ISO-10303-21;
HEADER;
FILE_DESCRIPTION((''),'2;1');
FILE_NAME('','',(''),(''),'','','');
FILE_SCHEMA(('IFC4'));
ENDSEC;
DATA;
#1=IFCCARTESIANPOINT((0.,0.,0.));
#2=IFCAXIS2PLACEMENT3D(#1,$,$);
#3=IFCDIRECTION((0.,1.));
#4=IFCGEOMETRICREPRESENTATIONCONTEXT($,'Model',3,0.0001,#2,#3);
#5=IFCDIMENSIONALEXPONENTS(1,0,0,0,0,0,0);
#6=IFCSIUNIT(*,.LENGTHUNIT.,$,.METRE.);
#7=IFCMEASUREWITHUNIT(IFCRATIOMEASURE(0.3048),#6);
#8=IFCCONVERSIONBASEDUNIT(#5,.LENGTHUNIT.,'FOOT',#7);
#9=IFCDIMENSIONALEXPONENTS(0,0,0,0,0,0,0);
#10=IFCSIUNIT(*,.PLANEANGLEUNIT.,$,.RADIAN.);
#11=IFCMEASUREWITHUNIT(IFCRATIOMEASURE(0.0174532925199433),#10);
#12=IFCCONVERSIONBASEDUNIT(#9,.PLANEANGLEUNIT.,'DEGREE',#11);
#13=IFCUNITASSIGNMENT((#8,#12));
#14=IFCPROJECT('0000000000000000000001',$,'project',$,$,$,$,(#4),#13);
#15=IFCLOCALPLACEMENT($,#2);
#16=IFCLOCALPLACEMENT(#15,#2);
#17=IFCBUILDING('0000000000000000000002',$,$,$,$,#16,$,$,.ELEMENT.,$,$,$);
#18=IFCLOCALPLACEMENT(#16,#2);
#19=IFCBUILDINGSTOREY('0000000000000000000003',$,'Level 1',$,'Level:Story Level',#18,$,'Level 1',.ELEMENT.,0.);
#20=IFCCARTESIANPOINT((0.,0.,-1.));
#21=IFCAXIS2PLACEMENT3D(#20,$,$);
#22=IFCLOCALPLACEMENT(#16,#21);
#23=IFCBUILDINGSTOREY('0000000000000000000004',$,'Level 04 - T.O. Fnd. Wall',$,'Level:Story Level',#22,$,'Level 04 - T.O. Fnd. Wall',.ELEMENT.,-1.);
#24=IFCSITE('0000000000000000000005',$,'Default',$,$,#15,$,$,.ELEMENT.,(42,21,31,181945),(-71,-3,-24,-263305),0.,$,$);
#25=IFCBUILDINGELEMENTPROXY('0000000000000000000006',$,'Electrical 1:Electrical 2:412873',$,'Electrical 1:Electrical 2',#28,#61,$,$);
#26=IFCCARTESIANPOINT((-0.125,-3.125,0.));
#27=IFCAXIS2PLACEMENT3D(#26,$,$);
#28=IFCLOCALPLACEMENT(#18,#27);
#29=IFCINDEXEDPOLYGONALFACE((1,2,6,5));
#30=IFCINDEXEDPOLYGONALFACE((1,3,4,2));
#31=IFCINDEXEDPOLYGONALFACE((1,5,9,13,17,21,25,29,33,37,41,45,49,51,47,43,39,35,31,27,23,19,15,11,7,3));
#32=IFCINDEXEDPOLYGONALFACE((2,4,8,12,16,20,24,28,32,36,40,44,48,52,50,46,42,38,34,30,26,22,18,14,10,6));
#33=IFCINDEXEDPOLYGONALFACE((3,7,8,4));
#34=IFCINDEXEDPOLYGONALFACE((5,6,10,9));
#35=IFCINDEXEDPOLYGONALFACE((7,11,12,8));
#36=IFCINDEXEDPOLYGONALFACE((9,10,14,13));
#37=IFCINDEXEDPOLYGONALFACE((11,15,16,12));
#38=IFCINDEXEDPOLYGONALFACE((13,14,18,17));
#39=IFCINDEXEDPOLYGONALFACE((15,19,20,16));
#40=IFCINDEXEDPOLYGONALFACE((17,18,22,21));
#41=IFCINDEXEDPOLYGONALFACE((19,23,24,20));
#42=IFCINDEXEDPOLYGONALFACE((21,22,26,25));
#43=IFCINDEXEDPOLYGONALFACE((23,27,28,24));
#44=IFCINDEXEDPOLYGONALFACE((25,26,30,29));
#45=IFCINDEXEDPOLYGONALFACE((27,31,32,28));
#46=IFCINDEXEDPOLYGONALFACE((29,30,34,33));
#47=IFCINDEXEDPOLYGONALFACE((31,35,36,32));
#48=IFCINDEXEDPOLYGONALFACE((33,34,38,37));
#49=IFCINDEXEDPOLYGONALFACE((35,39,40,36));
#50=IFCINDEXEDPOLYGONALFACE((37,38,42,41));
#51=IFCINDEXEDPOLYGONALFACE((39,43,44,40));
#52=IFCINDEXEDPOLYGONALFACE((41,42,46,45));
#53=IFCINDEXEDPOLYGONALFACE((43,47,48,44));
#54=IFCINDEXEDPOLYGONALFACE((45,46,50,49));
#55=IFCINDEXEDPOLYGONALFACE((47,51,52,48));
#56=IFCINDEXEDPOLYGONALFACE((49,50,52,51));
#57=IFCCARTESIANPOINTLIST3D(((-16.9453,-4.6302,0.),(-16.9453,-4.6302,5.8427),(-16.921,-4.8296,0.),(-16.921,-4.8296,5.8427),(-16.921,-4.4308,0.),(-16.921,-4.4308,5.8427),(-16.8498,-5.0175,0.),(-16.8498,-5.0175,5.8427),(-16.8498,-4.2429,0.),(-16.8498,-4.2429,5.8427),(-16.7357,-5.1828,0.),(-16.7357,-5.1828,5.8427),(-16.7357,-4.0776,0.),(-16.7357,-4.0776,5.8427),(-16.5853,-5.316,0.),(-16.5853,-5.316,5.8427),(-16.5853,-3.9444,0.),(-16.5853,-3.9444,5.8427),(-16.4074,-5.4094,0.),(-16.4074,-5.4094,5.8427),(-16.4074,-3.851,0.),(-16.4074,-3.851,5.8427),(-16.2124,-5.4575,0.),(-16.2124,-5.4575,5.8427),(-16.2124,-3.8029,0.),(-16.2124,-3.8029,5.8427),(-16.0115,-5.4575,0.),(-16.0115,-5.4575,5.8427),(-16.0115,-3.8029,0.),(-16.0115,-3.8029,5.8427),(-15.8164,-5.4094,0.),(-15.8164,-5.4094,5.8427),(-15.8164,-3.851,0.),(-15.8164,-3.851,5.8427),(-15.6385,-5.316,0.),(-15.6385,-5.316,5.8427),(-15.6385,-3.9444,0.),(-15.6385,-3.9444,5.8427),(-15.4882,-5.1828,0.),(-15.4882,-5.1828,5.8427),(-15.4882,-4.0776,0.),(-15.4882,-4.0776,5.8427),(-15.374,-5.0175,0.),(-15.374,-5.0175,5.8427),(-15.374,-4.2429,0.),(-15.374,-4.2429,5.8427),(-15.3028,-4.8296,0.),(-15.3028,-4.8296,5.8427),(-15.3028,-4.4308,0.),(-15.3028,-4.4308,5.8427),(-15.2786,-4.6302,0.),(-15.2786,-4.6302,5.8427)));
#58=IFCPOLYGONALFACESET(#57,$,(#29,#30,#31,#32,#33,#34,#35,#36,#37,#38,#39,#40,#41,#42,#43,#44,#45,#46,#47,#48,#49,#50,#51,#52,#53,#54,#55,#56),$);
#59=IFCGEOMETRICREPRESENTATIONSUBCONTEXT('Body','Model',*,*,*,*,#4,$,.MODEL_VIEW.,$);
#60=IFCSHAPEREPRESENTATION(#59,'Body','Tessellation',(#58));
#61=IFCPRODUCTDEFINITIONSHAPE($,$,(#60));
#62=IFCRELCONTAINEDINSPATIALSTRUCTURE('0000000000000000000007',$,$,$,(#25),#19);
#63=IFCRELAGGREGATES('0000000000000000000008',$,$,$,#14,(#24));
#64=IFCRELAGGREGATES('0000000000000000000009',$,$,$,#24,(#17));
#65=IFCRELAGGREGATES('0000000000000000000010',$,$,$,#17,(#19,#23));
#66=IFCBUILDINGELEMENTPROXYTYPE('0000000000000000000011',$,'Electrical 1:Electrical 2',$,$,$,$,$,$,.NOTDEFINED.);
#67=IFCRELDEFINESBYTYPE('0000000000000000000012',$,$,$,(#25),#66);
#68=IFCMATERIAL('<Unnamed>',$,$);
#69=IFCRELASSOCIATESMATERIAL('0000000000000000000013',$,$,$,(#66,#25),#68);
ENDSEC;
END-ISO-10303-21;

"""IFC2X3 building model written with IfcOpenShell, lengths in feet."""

from ifc_helpers import new_model, entity, si_unit, converted_unit, direction, frame, frame_2d, origin, place, context, subcontext, project, spatial, circle, extrude, source, transform, mapped, material, type_object, type_shapes, element, save


model = new_model("IFC2X3")

# Units and contexts
model_context = context("Model", 3, precision=0.0001, world=origin(), true_north=direction((0.0, 1.0)))
body_context = subcontext(model_context, "Body", "Model", "MODEL_VIEW")
ifc_project = project(units=[converted_unit("LENGTHUNIT", "FOOT", entity("IfcRatioMeasure", 0.3048), si_unit("LENGTHUNIT", "METRE"), dimensions=[1, 0, 0, 0, 0, 0, 0]), converted_unit("PLANEANGLEUNIT", "DEGREE", entity("IfcRatioMeasure", 0.0174532925199433), si_unit("PLANEANGLEUNIT", "RADIAN"), dimensions=[0, 0, 0, 0, 0, 0, 0])], contexts=[model_context])

# Site, building, storey
site_placement = place(None, origin())
site = spatial("IfcSite", under=ifc_project, at=site_placement, Name="Default", CompositionType="ELEMENT", RefLatitude=(42, 21, 31, 181945), RefLongitude=(-71, -3, -24, -263305), RefElevation=0.0)
building_placement = place(site_placement, origin())
building = spatial("IfcBuilding", under=site, at=building_placement, CompositionType="ELEMENT")
storey_1_placement = place(building_placement, origin())
storey_1 = spatial("IfcBuildingStorey", under=building, at=storey_1_placement, Name="Level 1", ObjectType="Level:Story Level", LongName="Level 1", CompositionType="ELEMENT", Elevation=0.0)

# Shared definitions
storey_2_placement = place(building_placement, frame((0.0, 0.0, -1.0)))
storey_2 = spatial("IfcBuildingStorey", under=building, at=storey_2_placement, Name="Level 04 - T.O. Fnd. Wall", ObjectType="Level:Story Level", LongName="Level 04 - T.O. Fnd. Wall", CompositionType="ELEMENT", Elevation=-1.0)

# Shared definitions
ifc_material_1 = material(Name="<Unnamed>")

# Building element proxy
building_element_proxy_type = type_object("IfcBuildingElementProxyType", Name="Electrical 1:Electrical 2", PredefinedType="NOTDEFINED", material=ifc_material_1)
shared_shape_1 = source(origin(), body_context, "Body", "SweptSolid", [
    extrude(circle(Radius=0.8333, at=frame_2d((0.0, 0.0), x_axis=(1.0, 0.0))), frame((-16.1119, -4.6302, 0.0)), (0.0, 0.0, 1.0), 5.8427),
])
type_shapes(building_element_proxy_type, [shared_shape_1])
proxy_placement = place(storey_1_placement, frame((-0.125, -3.125, 0.0)))
element("IfcBuildingElementProxy", 1, at=proxy_placement, inside=storey_1, type_object=building_element_proxy_type, material=ifc_material_1, Name="Electrical 1:Electrical 2:412873", ObjectType="Electrical 1:Electrical 2", context=body_context, shape_type="MappedRepresentation", body=[
    mapped(shared_shape_1, transform((0.0, 0.0, 0.0), scale=1.0)),
])

save(model, "model.ifc")
